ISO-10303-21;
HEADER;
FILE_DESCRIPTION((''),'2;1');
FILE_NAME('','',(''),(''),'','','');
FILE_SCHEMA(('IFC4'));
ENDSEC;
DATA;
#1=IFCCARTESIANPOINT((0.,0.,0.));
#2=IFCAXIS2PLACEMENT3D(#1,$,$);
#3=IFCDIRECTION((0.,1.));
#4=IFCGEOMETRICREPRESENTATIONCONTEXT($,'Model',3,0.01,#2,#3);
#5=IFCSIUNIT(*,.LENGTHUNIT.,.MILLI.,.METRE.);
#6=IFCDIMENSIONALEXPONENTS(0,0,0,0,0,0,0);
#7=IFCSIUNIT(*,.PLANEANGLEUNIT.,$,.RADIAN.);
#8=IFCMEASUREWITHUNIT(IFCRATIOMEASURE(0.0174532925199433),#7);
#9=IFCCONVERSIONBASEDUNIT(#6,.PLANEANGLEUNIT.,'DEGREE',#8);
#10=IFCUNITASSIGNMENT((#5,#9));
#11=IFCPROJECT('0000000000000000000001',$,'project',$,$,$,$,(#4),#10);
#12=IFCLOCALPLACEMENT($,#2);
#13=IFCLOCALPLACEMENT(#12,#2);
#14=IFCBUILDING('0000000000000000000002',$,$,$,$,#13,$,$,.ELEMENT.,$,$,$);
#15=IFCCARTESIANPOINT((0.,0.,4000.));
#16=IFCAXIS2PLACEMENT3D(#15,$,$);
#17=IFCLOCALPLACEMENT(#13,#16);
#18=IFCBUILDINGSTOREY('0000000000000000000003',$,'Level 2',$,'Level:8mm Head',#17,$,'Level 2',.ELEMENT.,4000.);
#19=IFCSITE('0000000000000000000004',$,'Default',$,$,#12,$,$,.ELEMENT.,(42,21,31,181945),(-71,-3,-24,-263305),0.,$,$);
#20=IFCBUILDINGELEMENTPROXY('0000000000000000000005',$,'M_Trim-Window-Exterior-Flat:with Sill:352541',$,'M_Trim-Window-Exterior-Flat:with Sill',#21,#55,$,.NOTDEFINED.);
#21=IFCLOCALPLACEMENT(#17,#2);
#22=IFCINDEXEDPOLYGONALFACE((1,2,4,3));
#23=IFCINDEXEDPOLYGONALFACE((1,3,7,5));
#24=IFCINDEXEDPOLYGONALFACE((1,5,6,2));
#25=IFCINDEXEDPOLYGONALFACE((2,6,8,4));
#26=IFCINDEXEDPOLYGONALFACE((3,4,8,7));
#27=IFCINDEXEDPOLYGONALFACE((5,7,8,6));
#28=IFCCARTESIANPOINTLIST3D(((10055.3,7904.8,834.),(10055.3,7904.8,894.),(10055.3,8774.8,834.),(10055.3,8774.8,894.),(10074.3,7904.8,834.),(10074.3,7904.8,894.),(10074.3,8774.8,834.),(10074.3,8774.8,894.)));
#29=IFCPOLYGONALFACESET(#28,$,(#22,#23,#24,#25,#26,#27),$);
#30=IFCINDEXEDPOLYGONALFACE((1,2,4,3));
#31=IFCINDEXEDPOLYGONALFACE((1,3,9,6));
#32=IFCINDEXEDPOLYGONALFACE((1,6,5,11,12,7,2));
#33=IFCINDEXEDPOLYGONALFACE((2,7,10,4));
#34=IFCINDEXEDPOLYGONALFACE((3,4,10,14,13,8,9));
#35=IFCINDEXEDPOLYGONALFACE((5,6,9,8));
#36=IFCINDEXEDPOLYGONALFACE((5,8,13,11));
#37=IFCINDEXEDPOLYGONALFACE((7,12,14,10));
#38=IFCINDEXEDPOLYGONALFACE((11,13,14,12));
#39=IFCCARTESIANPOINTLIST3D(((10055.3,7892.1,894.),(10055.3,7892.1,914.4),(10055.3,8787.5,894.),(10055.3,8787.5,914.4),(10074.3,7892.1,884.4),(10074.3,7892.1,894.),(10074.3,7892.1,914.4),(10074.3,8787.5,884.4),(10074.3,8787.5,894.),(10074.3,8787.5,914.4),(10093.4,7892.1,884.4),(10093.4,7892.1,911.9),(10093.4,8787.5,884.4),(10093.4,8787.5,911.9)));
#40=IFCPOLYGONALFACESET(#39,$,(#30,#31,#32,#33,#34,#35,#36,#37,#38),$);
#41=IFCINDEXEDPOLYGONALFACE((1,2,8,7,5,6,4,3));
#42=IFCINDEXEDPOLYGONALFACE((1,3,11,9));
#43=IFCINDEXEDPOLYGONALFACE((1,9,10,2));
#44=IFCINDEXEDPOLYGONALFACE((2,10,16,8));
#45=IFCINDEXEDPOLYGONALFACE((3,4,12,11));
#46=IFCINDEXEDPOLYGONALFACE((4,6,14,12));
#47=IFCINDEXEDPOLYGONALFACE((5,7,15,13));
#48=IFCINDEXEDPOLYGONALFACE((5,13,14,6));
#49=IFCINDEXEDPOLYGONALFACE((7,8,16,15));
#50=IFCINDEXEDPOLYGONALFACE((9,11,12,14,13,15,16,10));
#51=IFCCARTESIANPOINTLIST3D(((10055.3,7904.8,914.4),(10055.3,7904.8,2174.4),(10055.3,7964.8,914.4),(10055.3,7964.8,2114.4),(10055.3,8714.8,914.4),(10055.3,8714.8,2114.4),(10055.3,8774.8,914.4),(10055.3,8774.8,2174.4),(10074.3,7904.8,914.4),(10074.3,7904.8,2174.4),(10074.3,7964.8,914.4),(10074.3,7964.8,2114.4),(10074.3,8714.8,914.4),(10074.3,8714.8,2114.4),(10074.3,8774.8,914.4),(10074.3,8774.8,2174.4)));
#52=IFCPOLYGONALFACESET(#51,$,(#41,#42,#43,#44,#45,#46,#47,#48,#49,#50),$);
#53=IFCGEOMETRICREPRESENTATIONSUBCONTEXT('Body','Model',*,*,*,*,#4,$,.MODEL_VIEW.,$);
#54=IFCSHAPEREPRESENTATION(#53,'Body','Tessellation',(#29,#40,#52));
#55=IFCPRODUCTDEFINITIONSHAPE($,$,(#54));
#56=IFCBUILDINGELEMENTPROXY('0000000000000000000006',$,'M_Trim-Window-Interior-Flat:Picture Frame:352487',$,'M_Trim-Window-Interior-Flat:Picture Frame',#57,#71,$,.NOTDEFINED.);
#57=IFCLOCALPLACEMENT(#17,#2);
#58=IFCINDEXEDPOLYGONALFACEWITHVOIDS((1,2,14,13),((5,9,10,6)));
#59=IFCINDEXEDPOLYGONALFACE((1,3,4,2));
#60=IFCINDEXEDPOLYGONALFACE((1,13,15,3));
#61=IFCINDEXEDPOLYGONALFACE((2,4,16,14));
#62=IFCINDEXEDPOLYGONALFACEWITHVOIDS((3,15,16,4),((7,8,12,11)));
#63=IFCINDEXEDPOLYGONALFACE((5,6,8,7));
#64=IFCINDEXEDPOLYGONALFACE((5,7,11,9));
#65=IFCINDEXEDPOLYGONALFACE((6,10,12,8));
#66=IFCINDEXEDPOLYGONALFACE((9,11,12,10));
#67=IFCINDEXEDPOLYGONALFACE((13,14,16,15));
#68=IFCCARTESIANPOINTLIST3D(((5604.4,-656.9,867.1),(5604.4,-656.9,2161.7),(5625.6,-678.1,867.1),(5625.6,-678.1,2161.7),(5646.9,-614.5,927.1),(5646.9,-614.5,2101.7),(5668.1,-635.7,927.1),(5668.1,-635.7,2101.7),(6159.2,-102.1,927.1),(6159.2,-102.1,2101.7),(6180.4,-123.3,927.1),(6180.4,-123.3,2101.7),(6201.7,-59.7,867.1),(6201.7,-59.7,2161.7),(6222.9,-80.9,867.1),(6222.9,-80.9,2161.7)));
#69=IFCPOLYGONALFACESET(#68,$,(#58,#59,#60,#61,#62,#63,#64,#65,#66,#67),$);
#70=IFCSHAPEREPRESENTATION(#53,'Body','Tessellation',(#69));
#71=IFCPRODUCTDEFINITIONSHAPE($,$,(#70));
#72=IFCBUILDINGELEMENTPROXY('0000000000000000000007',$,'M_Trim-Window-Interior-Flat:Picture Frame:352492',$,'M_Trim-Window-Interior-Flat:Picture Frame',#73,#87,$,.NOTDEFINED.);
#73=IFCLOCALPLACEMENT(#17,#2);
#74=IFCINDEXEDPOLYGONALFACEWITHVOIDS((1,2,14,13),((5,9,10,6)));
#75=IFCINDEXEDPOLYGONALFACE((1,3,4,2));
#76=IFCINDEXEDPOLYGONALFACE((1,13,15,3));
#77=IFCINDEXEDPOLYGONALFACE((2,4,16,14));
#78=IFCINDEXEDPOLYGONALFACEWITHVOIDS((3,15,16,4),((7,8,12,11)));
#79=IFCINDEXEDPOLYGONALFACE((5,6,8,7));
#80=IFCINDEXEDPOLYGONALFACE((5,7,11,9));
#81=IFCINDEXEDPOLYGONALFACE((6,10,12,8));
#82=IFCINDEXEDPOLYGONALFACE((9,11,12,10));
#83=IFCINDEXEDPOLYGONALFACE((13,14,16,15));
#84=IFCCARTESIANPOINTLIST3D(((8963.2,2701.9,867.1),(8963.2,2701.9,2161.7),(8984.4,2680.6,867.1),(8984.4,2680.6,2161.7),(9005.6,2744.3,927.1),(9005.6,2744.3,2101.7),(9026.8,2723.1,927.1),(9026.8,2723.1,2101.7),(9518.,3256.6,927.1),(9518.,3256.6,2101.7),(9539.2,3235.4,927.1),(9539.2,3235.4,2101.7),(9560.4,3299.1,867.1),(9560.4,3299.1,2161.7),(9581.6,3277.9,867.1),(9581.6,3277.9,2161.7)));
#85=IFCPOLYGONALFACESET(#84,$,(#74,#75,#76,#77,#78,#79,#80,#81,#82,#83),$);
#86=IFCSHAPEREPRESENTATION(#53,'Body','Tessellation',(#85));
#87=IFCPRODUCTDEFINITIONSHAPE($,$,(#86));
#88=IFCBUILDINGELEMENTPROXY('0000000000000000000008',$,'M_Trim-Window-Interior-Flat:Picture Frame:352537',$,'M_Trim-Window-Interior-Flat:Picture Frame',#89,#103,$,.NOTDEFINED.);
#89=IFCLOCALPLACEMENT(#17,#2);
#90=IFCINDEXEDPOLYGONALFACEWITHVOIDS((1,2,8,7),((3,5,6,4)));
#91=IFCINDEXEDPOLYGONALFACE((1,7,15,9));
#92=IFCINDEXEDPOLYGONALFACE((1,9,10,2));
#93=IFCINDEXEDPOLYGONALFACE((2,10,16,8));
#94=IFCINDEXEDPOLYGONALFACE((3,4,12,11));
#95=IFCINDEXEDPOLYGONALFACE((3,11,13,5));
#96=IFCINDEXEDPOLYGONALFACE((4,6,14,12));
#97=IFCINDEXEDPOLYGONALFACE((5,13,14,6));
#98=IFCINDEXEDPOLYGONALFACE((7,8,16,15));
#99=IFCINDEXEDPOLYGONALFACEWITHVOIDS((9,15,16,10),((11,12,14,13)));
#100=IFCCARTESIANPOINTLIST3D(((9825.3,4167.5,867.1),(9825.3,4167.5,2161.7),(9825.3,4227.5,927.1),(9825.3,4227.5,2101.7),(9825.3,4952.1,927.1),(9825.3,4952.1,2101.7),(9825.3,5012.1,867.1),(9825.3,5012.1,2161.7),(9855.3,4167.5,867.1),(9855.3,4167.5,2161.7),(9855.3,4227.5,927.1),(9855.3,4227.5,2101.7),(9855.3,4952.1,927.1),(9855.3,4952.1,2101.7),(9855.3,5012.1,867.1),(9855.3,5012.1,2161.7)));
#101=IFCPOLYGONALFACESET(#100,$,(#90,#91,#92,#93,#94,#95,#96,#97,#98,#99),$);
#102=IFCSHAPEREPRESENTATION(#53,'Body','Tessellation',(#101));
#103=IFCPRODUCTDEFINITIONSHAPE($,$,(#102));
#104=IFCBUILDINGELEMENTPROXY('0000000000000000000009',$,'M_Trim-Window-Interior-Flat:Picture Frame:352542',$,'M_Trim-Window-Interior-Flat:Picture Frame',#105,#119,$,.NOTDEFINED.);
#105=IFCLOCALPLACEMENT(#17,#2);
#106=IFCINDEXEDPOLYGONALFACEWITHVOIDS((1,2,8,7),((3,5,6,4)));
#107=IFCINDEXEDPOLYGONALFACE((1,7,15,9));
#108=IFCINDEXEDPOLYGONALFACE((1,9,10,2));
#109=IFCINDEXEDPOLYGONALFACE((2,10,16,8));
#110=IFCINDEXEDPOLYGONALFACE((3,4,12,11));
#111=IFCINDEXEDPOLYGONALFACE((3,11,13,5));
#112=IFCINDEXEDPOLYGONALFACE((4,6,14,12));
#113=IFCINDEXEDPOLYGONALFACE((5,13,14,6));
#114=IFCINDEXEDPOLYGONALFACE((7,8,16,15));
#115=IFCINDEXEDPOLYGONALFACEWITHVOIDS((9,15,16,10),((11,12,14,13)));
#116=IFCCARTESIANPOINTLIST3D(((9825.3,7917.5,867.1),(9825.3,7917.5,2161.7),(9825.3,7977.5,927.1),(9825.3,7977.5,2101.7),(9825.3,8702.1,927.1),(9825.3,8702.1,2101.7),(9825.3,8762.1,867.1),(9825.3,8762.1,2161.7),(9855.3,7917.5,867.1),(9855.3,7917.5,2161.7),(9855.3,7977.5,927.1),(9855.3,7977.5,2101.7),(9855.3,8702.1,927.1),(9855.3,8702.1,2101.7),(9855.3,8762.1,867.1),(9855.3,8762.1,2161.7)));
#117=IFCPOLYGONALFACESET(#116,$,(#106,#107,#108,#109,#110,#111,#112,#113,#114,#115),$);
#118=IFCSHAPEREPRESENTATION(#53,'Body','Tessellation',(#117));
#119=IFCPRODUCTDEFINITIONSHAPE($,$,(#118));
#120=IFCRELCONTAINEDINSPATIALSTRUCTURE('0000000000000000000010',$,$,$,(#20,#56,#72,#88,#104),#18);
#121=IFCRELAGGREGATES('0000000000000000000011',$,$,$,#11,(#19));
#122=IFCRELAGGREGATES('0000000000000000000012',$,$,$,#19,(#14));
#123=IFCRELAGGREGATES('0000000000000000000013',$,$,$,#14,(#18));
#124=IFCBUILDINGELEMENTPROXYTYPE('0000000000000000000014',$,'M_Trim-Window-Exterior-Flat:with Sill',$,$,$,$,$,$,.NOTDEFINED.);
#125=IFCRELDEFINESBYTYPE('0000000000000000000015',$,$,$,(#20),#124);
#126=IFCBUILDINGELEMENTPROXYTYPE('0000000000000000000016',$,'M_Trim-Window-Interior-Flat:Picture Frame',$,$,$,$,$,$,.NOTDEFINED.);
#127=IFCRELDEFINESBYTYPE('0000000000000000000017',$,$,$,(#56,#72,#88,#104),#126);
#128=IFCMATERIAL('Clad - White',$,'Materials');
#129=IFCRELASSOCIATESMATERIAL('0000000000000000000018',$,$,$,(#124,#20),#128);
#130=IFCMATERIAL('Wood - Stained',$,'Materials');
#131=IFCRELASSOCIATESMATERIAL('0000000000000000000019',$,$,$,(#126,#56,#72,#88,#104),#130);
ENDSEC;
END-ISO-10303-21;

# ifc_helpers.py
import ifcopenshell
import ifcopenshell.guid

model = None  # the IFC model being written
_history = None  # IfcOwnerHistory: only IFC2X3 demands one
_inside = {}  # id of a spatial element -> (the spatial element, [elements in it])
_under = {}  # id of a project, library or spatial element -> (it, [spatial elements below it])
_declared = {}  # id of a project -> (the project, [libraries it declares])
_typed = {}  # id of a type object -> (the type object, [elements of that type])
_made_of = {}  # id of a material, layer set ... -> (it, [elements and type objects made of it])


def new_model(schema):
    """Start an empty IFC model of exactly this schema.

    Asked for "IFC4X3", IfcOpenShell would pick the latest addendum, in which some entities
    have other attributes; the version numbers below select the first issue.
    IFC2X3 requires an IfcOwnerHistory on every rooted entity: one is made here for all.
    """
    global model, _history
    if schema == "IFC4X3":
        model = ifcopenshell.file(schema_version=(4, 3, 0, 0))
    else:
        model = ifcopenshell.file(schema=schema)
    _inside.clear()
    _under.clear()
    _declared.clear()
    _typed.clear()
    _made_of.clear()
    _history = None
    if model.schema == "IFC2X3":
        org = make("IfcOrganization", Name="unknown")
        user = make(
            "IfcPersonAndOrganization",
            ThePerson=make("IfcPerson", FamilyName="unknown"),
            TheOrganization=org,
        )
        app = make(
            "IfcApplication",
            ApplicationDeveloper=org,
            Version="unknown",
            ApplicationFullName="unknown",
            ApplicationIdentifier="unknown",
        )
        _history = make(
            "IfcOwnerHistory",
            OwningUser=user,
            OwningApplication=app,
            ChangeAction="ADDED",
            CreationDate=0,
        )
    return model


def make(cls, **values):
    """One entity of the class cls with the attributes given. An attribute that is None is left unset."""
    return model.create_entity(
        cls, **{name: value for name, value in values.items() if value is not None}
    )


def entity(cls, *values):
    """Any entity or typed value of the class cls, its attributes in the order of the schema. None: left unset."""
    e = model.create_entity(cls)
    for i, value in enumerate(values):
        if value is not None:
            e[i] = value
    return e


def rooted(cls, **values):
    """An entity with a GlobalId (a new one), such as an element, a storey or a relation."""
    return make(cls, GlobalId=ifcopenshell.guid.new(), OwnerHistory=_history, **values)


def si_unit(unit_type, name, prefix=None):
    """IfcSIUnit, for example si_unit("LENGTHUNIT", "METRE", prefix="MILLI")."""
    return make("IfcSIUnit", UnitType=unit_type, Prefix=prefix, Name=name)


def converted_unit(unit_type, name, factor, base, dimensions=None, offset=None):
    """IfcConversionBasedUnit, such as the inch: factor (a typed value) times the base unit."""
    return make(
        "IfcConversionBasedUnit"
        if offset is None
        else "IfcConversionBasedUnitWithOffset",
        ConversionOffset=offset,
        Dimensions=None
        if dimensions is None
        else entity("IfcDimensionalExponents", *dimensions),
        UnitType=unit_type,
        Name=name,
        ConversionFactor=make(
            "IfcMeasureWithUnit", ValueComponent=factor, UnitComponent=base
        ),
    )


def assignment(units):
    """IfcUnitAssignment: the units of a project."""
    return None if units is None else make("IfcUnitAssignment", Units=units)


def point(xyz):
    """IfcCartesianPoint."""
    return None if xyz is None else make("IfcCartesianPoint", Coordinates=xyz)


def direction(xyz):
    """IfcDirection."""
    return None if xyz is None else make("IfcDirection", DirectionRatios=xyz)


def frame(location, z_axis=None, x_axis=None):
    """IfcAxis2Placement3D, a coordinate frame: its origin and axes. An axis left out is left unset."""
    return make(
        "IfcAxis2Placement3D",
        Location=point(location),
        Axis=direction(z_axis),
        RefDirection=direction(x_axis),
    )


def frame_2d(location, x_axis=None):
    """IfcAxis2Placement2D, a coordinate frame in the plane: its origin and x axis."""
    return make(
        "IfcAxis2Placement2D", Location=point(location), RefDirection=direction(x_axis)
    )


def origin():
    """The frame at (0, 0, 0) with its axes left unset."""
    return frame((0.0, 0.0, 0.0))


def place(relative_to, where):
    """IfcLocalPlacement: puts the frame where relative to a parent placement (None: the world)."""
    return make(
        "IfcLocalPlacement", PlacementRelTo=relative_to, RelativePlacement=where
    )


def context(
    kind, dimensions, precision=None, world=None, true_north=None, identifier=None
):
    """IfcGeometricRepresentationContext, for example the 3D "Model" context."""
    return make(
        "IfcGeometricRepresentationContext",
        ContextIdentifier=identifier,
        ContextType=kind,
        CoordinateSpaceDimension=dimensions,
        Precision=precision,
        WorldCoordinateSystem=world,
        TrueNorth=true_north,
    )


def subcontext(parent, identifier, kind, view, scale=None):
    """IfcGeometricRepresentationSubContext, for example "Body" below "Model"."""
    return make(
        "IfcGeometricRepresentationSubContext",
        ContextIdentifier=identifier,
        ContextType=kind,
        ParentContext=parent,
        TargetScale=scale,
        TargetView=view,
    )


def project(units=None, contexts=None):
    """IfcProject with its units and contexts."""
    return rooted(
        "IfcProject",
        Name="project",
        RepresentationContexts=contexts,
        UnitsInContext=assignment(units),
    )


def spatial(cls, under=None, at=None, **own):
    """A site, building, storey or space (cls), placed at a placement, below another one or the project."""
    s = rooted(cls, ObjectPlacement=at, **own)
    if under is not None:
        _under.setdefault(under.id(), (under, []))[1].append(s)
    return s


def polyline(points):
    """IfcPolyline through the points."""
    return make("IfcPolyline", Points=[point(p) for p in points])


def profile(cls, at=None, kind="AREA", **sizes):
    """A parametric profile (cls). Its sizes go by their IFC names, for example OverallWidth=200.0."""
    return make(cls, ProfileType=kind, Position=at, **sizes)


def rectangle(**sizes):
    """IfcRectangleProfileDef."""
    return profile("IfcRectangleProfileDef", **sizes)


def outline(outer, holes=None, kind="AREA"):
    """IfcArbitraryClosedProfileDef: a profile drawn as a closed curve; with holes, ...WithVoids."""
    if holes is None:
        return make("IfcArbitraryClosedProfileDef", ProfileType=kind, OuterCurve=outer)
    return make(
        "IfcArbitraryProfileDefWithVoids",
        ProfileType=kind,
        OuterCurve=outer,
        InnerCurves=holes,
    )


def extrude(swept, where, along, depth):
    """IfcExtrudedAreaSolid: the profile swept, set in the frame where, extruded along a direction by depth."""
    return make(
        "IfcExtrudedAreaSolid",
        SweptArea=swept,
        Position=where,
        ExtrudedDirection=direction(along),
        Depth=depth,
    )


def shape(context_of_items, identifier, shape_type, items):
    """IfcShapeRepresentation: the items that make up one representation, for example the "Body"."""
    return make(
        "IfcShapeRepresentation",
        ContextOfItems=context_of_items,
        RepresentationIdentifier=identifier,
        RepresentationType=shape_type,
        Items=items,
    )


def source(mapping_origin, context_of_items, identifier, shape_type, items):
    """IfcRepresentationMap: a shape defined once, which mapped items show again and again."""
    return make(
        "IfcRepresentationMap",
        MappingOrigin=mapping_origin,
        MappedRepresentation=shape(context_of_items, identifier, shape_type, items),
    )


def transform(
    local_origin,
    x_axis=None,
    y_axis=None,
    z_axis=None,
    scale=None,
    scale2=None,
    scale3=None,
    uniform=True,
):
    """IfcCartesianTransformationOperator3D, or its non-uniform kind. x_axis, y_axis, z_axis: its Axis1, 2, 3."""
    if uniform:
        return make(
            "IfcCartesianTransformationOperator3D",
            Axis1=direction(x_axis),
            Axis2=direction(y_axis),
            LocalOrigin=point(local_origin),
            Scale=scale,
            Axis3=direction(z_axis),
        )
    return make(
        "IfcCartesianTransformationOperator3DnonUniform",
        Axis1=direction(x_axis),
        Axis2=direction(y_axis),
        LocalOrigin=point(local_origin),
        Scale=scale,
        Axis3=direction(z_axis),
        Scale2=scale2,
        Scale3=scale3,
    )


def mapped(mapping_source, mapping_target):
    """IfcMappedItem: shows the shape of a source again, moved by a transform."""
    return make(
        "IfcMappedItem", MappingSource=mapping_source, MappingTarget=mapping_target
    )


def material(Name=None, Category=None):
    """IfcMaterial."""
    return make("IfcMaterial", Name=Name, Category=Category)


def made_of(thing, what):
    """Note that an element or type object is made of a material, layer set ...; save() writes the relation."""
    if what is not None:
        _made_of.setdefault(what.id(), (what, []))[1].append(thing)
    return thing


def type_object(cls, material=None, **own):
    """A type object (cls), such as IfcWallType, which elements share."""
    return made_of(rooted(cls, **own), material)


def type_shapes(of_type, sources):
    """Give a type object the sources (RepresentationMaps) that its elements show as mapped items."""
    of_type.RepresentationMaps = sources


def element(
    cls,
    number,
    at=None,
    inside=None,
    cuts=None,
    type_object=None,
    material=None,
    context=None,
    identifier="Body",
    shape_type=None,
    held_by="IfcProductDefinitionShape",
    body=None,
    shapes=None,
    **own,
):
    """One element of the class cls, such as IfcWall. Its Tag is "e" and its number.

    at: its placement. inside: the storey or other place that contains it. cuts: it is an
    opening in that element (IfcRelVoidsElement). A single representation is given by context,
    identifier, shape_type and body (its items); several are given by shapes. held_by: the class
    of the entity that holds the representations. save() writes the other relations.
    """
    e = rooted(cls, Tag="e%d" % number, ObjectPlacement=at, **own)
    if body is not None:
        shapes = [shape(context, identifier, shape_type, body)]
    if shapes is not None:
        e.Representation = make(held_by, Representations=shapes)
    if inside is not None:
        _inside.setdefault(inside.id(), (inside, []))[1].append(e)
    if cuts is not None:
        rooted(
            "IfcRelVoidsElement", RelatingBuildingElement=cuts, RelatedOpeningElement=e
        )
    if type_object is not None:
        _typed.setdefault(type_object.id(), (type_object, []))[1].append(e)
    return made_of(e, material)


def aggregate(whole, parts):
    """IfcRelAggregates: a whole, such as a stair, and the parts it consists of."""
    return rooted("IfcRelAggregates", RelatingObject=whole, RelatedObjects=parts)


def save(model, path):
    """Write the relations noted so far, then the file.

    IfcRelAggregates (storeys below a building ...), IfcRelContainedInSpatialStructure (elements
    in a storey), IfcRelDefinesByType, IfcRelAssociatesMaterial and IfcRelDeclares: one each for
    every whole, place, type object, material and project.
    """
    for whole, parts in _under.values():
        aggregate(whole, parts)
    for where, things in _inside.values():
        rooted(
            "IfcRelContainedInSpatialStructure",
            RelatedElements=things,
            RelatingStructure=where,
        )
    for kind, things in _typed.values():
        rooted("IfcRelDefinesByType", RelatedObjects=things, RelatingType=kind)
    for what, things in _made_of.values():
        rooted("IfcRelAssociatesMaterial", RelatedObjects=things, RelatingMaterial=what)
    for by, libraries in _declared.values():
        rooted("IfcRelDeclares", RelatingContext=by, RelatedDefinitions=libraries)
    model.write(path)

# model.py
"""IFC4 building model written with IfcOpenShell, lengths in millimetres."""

from ifc_helpers import new_model, entity, si_unit, converted_unit, direction, frame, frame_2d, origin, place, context, subcontext, project, spatial, polyline, rectangle, outline, extrude, source, transform, mapped, material, type_object, type_shapes, element, save


model = new_model("IFC4")

# Units and contexts
model_context = context("Model", 3, precision=0.01, world=origin(), true_north=direction((0.0, 1.0)))
body_context = subcontext(model_context, "Body", "Model", "MODEL_VIEW")
ifc_project = project(units=[si_unit("LENGTHUNIT", "METRE", prefix="MILLI"), converted_unit("PLANEANGLEUNIT", "DEGREE", entity("IfcRatioMeasure", 0.0174532925199433), si_unit("PLANEANGLEUNIT", "RADIAN"), dimensions=[0, 0, 0, 0, 0, 0, 0])], contexts=[model_context])

# Site, building, storey
site_placement = place(None, origin())
site = spatial("IfcSite", under=ifc_project, at=site_placement, Name="Default", CompositionType="ELEMENT", RefLatitude=(42, 21, 31, 181945), RefLongitude=(-71, -3, -24, -263305), RefElevation=0.0)
building_placement = place(site_placement, origin())
building = spatial("IfcBuilding", under=site, at=building_placement, CompositionType="ELEMENT")
storey_placement = place(building_placement, frame((0.0, 0.0, 4000.0)))
storey = spatial("IfcBuildingStorey", under=building, at=storey_placement, Name="Level 2", ObjectType="Level:8mm Head", LongName="Level 2", CompositionType="ELEMENT", Elevation=4000.0)

# Shared definitions
ifc_material_1 = material(Name="Wood - Stained", Category="Materials")

# Building element proxies
ifc_material_2 = material(Name="Clad - White", Category="Materials")
building_element_proxy_type_1 = type_object("IfcBuildingElementProxyType", Name="M_Trim-Window-Exterior-Flat:with Sill", PredefinedType="NOTDEFINED", material=ifc_material_2)
shared_shape_1 = source(origin(), body_context, "Body", "SweptSolid", [
    extrude(rectangle(XDim=870.0, YDim=60.0, at=frame_2d((0.0, 0.0), x_axis=(1.0, 0.0))), frame((0.0, -1250.4, 0.0), z_axis=(0.0, 0.0, 1.0), x_axis=(-1.0, 0.0, 0.0)), (0.0, 0.0, 1.0), 19.1),
    extrude(outline(polyline([(-19.0, -15.2), (0.0, -15.2), (0.0, -5.7), (19.0, -5.7), (19.0, 14.8), (0.0, 14.8), (-19.0, 12.3), (-19.0, -15.2)])), frame((-447.7, -1214.8, 19.0), z_axis=(1.0, 0.0, 0.0), x_axis=(0.0, 0.0, -1.0)), (0.0, 0.0, 1.0), 895.4),
    extrude(outline(polyline([(-645.0, -435.0), (615.0, -435.0), (615.0, -375.0), (-585.0, -375.0), (-585.0, 375.0), (615.0, 375.0), (615.0, 435.0), (-645.0, 435.0), (-645.0, -435.0)])), frame((0.0, -585.0, 0.0), z_axis=(0.0, 0.0, 1.0), x_axis=(0.0, -1.0, 0.0)), (0.0, 0.0, 1.0), 19.1),
])
type_shapes(building_element_proxy_type_1, [shared_shape_1])
for number, where, z_axis, x_axis, name in (
    (1, (10055.3, 8339.8, 2114.4), (1.0, 0.0, 0.0), (0.0, 1.0, 0.0), "M_Trim-Window-Exterior-Flat:with Sill:352541"),
):
    element("IfcBuildingElementProxy", number, at=place(storey_placement, frame(where, z_axis=z_axis, x_axis=x_axis)), inside=storey, type_object=building_element_proxy_type_1, material=ifc_material_2, Name=name, ObjectType="M_Trim-Window-Exterior-Flat:with Sill", PredefinedType="NOTDEFINED", context=body_context, shape_type="MappedRepresentation", body=[
        mapped(shared_shape_1, transform((0.0, 0.0, 0.0), scale=1.0)),
    ])
building_element_proxy_type_2 = type_object("IfcBuildingElementProxyType", Name="M_Trim-Window-Interior-Flat:Picture Frame", PredefinedType="NOTDEFINED", material=ifc_material_1)
shared_shape_2 = source(origin(), body_context, "Body", "SweptSolid", [
    extrude(outline(polyline([(-422.3, -647.3), (422.3, -647.3), (422.3, 647.3), (-422.3, 647.3), (-422.3, -647.3)]), holes=[polyline([(-362.3, -587.3), (-362.3, 587.3), (362.3, 587.3), (362.3, -587.3), (-362.3, -587.3)])]), frame((0.0, -600.0, 0.0), z_axis=(0.0, 0.0, 1.0), x_axis=(-1.0, 0.0, 0.0)), (0.0, 0.0, 1.0), 30.0),
])
type_shapes(building_element_proxy_type_2, [shared_shape_2])
for number, where, z_axis, x_axis, name in (
    (2, (5903.0, -358.3, 2114.4), (0.707107, -0.707107, 0.0), (0.707107, 0.707107, 0.0), "M_Trim-Window-Interior-Flat:Picture Frame:352487"),
    (3, (9261.8, 3000.5, 2114.4), (0.707107, -0.707107, 0.0), (0.707107, 0.707107, 0.0), "M_Trim-Window-Interior-Flat:Picture Frame:352492"),
    (4, (9855.3, 4589.8, 2114.4), (-1.0, 0.0, 0.0), (0.0, -1.0, 0.0), "M_Trim-Window-Interior-Flat:Picture Frame:352537"),
    (5, (9855.3, 8339.8, 2114.4), (-1.0, 0.0, 0.0), (0.0, -1.0, 0.0), "M_Trim-Window-Interior-Flat:Picture Frame:352542"),
):
    element("IfcBuildingElementProxy", number, at=place(storey_placement, frame(where, z_axis=z_axis, x_axis=x_axis)), inside=storey, type_object=building_element_proxy_type_2, material=ifc_material_1, Name=name, ObjectType="M_Trim-Window-Interior-Flat:Picture Frame", PredefinedType="NOTDEFINED", context=body_context, shape_type="MappedRepresentation", body=[
        mapped(shared_shape_2, transform((0.0, 0.0, 0.0), scale=1.0)),
    ])

save(model, "model.ifc")
